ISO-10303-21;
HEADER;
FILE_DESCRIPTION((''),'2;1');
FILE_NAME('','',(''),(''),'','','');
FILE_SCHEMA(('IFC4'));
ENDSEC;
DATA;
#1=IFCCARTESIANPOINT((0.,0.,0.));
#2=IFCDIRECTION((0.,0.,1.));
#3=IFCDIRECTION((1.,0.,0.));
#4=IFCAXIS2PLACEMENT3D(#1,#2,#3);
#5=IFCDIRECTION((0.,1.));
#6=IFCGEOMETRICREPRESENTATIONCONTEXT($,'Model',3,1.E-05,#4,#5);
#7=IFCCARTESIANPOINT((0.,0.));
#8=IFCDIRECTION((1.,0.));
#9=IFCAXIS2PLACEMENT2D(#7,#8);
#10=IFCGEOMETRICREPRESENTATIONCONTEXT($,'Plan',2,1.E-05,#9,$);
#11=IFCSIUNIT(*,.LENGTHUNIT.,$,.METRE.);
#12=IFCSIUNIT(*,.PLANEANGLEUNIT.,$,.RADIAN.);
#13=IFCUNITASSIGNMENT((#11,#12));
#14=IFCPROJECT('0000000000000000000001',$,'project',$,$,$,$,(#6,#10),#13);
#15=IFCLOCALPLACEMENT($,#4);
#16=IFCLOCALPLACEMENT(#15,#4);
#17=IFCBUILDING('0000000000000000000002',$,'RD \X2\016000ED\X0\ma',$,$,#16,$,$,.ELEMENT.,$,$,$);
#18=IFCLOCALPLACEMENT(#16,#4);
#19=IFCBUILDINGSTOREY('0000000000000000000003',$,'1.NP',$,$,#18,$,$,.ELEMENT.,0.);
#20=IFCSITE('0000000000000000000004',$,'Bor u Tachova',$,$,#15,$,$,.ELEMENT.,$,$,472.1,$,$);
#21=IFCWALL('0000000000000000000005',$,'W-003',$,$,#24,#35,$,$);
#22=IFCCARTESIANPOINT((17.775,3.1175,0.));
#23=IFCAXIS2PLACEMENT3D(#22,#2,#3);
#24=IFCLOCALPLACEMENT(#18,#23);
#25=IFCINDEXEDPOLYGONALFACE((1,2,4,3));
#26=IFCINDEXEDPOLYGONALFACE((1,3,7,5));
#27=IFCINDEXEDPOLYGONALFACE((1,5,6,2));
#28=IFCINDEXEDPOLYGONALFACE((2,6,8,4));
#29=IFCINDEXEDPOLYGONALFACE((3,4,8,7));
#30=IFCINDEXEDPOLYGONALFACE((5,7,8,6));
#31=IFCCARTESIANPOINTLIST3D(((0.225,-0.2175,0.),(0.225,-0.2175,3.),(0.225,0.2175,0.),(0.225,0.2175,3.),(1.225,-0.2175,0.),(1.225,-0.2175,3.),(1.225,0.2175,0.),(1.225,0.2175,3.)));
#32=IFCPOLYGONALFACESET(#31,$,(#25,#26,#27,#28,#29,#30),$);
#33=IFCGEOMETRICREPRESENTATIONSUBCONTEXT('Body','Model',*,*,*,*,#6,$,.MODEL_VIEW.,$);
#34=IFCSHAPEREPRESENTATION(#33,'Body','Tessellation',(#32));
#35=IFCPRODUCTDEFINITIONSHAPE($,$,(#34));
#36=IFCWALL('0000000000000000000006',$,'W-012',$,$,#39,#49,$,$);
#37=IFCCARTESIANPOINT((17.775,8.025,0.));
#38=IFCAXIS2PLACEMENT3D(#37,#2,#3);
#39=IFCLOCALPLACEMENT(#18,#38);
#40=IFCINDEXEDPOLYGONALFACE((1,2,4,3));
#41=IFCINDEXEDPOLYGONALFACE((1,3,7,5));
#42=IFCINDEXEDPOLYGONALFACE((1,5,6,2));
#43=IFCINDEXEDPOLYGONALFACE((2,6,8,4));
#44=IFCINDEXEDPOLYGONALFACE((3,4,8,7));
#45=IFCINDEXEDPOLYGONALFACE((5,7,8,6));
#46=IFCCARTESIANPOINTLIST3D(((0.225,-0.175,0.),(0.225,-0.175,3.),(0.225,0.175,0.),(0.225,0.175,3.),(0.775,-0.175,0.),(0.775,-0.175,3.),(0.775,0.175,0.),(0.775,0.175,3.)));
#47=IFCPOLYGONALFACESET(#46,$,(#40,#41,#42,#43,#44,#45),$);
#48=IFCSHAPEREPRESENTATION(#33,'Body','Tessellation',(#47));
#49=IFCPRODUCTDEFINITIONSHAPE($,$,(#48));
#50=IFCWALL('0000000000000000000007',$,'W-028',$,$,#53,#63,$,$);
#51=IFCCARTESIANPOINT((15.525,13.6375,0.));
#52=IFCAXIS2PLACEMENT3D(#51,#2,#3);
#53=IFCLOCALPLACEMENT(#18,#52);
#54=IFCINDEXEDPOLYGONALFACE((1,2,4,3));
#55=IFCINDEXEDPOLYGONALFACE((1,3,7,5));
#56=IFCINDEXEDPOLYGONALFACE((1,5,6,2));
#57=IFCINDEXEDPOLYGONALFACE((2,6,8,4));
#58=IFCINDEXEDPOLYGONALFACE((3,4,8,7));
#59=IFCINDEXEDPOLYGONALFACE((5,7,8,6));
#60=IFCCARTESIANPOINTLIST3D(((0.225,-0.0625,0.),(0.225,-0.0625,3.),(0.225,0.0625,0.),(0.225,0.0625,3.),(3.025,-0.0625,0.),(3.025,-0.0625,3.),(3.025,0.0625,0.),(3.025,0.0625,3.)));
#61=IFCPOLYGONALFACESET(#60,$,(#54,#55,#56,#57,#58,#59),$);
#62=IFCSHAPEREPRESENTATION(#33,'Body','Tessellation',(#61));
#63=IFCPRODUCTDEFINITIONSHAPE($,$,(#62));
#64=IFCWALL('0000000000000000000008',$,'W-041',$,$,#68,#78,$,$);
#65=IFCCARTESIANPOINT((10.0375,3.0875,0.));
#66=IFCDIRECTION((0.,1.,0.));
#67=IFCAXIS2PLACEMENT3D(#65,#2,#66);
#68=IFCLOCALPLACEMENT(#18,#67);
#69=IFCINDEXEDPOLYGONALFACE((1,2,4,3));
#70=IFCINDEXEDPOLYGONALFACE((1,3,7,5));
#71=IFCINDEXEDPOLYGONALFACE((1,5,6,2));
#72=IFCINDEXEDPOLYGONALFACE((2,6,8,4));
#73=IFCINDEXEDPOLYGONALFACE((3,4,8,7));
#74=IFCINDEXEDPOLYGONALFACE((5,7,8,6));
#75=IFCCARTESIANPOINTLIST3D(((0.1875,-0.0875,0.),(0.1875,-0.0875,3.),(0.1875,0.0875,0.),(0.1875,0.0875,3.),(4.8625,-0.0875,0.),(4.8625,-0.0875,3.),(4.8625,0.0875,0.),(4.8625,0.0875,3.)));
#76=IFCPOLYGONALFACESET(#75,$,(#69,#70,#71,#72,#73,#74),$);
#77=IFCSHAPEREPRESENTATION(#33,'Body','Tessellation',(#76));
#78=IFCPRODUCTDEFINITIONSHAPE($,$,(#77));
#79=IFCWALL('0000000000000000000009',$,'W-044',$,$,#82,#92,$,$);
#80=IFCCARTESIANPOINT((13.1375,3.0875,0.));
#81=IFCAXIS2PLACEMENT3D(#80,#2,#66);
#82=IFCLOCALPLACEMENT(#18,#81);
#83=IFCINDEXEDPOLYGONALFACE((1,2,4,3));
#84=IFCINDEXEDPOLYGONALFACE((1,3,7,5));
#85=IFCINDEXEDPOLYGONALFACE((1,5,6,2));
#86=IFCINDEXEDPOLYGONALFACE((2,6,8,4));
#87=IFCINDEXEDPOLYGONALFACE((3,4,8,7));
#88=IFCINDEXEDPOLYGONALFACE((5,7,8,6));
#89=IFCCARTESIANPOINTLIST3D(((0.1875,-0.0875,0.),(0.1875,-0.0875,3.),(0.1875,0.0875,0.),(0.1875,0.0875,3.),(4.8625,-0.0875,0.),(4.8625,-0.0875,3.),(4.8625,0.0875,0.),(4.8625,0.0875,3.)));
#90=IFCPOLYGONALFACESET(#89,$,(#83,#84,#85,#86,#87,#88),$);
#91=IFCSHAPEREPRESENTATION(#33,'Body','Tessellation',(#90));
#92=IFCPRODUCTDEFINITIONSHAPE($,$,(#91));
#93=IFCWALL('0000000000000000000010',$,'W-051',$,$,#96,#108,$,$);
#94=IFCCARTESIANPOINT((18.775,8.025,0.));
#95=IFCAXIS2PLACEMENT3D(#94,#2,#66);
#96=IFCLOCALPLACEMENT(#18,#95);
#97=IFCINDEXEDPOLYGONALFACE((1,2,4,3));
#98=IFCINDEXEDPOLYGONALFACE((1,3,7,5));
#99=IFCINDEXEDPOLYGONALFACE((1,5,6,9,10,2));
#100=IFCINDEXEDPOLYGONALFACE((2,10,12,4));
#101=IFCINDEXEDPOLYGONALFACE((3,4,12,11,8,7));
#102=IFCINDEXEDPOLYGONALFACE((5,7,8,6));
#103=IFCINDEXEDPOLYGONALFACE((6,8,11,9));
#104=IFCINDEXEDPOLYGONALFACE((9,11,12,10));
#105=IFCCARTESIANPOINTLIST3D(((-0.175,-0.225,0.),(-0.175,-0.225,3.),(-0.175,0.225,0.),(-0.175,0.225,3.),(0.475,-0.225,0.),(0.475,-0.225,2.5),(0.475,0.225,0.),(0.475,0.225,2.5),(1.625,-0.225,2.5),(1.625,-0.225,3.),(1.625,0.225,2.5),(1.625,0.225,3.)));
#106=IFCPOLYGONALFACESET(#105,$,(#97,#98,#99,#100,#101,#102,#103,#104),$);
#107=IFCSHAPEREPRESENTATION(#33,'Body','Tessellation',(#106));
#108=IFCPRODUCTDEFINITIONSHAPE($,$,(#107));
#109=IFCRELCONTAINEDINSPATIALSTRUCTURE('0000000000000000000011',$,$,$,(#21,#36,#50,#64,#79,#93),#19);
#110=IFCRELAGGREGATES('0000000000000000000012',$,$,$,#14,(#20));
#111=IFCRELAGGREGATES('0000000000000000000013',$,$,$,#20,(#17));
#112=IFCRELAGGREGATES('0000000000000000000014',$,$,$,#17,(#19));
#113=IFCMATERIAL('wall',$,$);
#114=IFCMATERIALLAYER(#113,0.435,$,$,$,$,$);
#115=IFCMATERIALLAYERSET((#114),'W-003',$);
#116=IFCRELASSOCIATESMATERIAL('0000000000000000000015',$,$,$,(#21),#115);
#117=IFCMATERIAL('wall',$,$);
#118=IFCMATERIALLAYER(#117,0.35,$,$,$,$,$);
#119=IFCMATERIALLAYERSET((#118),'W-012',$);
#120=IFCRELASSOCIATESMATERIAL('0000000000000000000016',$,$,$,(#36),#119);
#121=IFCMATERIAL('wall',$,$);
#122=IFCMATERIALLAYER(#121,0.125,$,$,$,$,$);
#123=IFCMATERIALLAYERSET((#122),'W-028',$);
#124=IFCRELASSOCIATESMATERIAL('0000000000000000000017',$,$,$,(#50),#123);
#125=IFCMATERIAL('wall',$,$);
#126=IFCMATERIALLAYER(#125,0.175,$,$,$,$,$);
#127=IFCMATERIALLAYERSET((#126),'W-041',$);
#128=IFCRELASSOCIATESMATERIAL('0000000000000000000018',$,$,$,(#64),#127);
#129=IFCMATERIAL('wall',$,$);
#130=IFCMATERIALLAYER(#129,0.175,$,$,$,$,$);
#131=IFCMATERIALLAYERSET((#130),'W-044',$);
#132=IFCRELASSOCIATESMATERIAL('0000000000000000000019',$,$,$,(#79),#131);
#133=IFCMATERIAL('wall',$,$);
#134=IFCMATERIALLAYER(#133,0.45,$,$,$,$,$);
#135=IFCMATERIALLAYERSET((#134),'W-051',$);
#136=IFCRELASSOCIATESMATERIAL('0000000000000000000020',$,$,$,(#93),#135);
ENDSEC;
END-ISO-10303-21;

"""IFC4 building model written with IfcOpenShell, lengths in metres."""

from ifc_helpers import new_model, si_unit, direction, frame, frame_2d, origin_with_axes, origin_2d_with_axis, place, context, subcontext, project, spatial, line, indexed_curve, rectangle, outline, extrude, material, layer, layer_set, layer_usage, element, save


model = new_model("IFC4")

# Units and contexts
model_context = context("Model", 3, precision=1e-05, world=origin_with_axes(), true_north=direction((0.0, 1.0)))
plan_context = context("Plan", 2, precision=1e-05, world=origin_2d_with_axis())
body_context = subcontext(model_context, "Body", "Model", "MODEL_VIEW")
ifc_project = project(units=[si_unit("LENGTHUNIT", "METRE"), si_unit("PLANEANGLEUNIT", "RADIAN")], contexts=[model_context, plan_context])

# Site, building, storey
site_placement = place(None, origin_with_axes())
site = spatial("IfcSite", under=ifc_project, at=site_placement, Name="Bor u Tachova", CompositionType="ELEMENT", RefElevation=472.1)
building_placement = place(site_placement, origin_with_axes())
building = spatial("IfcBuilding", under=site, at=building_placement, Name="RD Šíma", CompositionType="ELEMENT")
storey_placement = place(building_placement, origin_with_axes())
storey = spatial("IfcBuildingStorey", under=building, at=storey_placement, Name="1.NP", CompositionType="ELEMENT", Elevation=0.0)

# Walls
ifc_material_1 = material(Name="wall")
ifc_layer_1 = layer(ifc_material_1, 0.435)
ifc_layer_set_1 = layer_set([ifc_layer_1], Name="W-003")
ifc_layer_usage_1 = layer_usage(ifc_layer_set_1, "AXIS2", "POSITIVE", -0.2175)
wall_1_placement = place(storey_placement, frame((17.775, 3.1175, 0.0), z_axis=(0.0, 0.0, 1.0), x_axis=(1.0, 0.0, 0.0)))
element("IfcWall", 1, at=wall_1_placement, inside=storey, material=ifc_layer_usage_1, Name="W-003", context=body_context, shape_type="SweptSolid", body=[
    extrude(outline(indexed_curve([(0.225, -0.2175), (0.225, 0.2175), (1.225, 0.2175), (1.225, -0.2175)], segments=[line(1, 2, 3, 4, 1)])), origin_with_axes(), (0.0, 0.0, 1.0), 3.0),
])
ifc_material_2 = material(Name="wall")
ifc_layer_2 = layer(ifc_material_2, 0.35)
ifc_layer_set_2 = layer_set([ifc_layer_2], Name="W-012")
ifc_layer_usage_2 = layer_usage(ifc_layer_set_2, "AXIS2", "POSITIVE", -0.175)
wall_2_placement = place(storey_placement, frame((17.775, 8.025, 0.0), z_axis=(0.0, 0.0, 1.0), x_axis=(1.0, 0.0, 0.0)))
element("IfcWall", 2, at=wall_2_placement, inside=storey, material=ifc_layer_usage_2, Name="W-012", context=body_context, shape_type="SweptSolid", body=[
    extrude(outline(indexed_curve([(0.225, -0.175), (0.225, 0.175), (0.775, 0.175), (0.775, -0.175)], segments=[line(1, 2, 3, 4, 1)])), origin_with_axes(), (0.0, 0.0, 1.0), 3.0),
])

# Walls
ifc_material_3 = material(Name="wall")
ifc_layer_3 = layer(ifc_material_3, 0.125)
ifc_layer_set_3 = layer_set([ifc_layer_3], Name="W-028")
ifc_layer_usage_3 = layer_usage(ifc_layer_set_3, "AXIS2", "POSITIVE", -0.0625)
wall_3_placement = place(storey_placement, frame((15.525, 13.6375, 0.0), z_axis=(0.0, 0.0, 1.0), x_axis=(1.0, 0.0, 0.0)))
element("IfcWall", 3, at=wall_3_placement, inside=storey, material=ifc_layer_usage_3, Name="W-028", context=body_context, shape_type="SweptSolid", body=[
    extrude(outline(indexed_curve([(0.225, -0.0625), (0.225, 0.0625), (3.025, 0.0625), (3.025, -0.0625)], segments=[line(1, 2, 3, 4, 1)])), origin_with_axes(), (0.0, 0.0, 1.0), 3.0),
])
ifc_material_4 = material(Name="wall")
ifc_layer_4 = layer(ifc_material_4, 0.175)
ifc_layer_set_4 = layer_set([ifc_layer_4], Name="W-041")
ifc_layer_usage_4 = layer_usage(ifc_layer_set_4, "AXIS2", "POSITIVE", -0.0875)
wall_4_placement = place(storey_placement, frame((10.0375, 3.0875, 0.0), z_axis=(0.0, 0.0, 1.0), x_axis=(0.0, 1.0, 0.0)))
element("IfcWall", 4, at=wall_4_placement, inside=storey, material=ifc_layer_usage_4, Name="W-041", context=body_context, shape_type="SweptSolid", body=[
    extrude(outline(indexed_curve([(0.1875, -0.0875), (0.1875, 0.0875), (4.8625, 0.0875), (4.8625, -0.0875)], segments=[line(1, 2, 3, 4, 1)])), origin_with_axes(), (0.0, 0.0, 1.0), 3.0),
])
ifc_material_5 = material(Name="wall")
ifc_layer_5 = layer(ifc_material_5, 0.175)
ifc_layer_set_5 = layer_set([ifc_layer_5], Name="W-044")
ifc_layer_usage_5 = layer_usage(ifc_layer_set_5, "AXIS2", "POSITIVE", -0.0875)
wall_5_placement = place(storey_placement, frame((13.1375, 3.0875, 0.0), z_axis=(0.0, 0.0, 1.0), x_axis=(0.0, 1.0, 0.0)))
element("IfcWall", 5, at=wall_5_placement, inside=storey, material=ifc_layer_usage_5, Name="W-044", context=body_context, shape_type="SweptSolid", body=[
    extrude(outline(indexed_curve([(0.1875, -0.0875), (0.1875, 0.0875), (4.8625, 0.0875), (4.8625, -0.0875)], segments=[line(1, 2, 3, 4, 1)])), origin_with_axes(), (0.0, 0.0, 1.0), 3.0),
])

# Wall, opening
ifc_material_6 = material(Name="wall")
ifc_layer_6 = layer(ifc_material_6, 0.45)
ifc_layer_set_6 = layer_set([ifc_layer_6], Name="W-051")
ifc_layer_usage_6 = layer_usage(ifc_layer_set_6, "AXIS2", "POSITIVE", -0.225)
wall_6_placement = place(storey_placement, frame((18.775, 8.025, 0.0), z_axis=(0.0, 0.0, 1.0), x_axis=(0.0, 1.0, 0.0)))
wall_6 = element("IfcWall", 6, at=wall_6_placement, inside=storey, material=ifc_layer_usage_6, Name="W-051", context=body_context, shape_type="SweptSolid", body=[
    extrude(outline(indexed_curve([(-0.175, -0.225), (-0.175, 0.225), (0.175, 0.225), (1.625, 0.225), (1.625, -0.225)], segments=[line(1, 2, 3, 4, 5, 1)])), origin_with_axes(), (0.0, 0.0, 1.0), 3.0),
])
opening_1_placement = place(wall_6_placement, frame((0.475, 0.0, 0.0), z_axis=(0.0, 0.0, 1.0), x_axis=(1.0, 0.0, 0.0)))
element("IfcOpeningElement", 7, at=opening_1_placement, cuts=wall_6, PredefinedType="OPENING", context=body_context, shape_type="SweptSolid", body=[
    extrude(rectangle(XDim=1.15, YDim=0.45, at=frame_2d((0.575, 0.0))), origin_with_axes(), (0.0, 0.0, 1.0), 2.5),
])

save(model, "model.ifc")
